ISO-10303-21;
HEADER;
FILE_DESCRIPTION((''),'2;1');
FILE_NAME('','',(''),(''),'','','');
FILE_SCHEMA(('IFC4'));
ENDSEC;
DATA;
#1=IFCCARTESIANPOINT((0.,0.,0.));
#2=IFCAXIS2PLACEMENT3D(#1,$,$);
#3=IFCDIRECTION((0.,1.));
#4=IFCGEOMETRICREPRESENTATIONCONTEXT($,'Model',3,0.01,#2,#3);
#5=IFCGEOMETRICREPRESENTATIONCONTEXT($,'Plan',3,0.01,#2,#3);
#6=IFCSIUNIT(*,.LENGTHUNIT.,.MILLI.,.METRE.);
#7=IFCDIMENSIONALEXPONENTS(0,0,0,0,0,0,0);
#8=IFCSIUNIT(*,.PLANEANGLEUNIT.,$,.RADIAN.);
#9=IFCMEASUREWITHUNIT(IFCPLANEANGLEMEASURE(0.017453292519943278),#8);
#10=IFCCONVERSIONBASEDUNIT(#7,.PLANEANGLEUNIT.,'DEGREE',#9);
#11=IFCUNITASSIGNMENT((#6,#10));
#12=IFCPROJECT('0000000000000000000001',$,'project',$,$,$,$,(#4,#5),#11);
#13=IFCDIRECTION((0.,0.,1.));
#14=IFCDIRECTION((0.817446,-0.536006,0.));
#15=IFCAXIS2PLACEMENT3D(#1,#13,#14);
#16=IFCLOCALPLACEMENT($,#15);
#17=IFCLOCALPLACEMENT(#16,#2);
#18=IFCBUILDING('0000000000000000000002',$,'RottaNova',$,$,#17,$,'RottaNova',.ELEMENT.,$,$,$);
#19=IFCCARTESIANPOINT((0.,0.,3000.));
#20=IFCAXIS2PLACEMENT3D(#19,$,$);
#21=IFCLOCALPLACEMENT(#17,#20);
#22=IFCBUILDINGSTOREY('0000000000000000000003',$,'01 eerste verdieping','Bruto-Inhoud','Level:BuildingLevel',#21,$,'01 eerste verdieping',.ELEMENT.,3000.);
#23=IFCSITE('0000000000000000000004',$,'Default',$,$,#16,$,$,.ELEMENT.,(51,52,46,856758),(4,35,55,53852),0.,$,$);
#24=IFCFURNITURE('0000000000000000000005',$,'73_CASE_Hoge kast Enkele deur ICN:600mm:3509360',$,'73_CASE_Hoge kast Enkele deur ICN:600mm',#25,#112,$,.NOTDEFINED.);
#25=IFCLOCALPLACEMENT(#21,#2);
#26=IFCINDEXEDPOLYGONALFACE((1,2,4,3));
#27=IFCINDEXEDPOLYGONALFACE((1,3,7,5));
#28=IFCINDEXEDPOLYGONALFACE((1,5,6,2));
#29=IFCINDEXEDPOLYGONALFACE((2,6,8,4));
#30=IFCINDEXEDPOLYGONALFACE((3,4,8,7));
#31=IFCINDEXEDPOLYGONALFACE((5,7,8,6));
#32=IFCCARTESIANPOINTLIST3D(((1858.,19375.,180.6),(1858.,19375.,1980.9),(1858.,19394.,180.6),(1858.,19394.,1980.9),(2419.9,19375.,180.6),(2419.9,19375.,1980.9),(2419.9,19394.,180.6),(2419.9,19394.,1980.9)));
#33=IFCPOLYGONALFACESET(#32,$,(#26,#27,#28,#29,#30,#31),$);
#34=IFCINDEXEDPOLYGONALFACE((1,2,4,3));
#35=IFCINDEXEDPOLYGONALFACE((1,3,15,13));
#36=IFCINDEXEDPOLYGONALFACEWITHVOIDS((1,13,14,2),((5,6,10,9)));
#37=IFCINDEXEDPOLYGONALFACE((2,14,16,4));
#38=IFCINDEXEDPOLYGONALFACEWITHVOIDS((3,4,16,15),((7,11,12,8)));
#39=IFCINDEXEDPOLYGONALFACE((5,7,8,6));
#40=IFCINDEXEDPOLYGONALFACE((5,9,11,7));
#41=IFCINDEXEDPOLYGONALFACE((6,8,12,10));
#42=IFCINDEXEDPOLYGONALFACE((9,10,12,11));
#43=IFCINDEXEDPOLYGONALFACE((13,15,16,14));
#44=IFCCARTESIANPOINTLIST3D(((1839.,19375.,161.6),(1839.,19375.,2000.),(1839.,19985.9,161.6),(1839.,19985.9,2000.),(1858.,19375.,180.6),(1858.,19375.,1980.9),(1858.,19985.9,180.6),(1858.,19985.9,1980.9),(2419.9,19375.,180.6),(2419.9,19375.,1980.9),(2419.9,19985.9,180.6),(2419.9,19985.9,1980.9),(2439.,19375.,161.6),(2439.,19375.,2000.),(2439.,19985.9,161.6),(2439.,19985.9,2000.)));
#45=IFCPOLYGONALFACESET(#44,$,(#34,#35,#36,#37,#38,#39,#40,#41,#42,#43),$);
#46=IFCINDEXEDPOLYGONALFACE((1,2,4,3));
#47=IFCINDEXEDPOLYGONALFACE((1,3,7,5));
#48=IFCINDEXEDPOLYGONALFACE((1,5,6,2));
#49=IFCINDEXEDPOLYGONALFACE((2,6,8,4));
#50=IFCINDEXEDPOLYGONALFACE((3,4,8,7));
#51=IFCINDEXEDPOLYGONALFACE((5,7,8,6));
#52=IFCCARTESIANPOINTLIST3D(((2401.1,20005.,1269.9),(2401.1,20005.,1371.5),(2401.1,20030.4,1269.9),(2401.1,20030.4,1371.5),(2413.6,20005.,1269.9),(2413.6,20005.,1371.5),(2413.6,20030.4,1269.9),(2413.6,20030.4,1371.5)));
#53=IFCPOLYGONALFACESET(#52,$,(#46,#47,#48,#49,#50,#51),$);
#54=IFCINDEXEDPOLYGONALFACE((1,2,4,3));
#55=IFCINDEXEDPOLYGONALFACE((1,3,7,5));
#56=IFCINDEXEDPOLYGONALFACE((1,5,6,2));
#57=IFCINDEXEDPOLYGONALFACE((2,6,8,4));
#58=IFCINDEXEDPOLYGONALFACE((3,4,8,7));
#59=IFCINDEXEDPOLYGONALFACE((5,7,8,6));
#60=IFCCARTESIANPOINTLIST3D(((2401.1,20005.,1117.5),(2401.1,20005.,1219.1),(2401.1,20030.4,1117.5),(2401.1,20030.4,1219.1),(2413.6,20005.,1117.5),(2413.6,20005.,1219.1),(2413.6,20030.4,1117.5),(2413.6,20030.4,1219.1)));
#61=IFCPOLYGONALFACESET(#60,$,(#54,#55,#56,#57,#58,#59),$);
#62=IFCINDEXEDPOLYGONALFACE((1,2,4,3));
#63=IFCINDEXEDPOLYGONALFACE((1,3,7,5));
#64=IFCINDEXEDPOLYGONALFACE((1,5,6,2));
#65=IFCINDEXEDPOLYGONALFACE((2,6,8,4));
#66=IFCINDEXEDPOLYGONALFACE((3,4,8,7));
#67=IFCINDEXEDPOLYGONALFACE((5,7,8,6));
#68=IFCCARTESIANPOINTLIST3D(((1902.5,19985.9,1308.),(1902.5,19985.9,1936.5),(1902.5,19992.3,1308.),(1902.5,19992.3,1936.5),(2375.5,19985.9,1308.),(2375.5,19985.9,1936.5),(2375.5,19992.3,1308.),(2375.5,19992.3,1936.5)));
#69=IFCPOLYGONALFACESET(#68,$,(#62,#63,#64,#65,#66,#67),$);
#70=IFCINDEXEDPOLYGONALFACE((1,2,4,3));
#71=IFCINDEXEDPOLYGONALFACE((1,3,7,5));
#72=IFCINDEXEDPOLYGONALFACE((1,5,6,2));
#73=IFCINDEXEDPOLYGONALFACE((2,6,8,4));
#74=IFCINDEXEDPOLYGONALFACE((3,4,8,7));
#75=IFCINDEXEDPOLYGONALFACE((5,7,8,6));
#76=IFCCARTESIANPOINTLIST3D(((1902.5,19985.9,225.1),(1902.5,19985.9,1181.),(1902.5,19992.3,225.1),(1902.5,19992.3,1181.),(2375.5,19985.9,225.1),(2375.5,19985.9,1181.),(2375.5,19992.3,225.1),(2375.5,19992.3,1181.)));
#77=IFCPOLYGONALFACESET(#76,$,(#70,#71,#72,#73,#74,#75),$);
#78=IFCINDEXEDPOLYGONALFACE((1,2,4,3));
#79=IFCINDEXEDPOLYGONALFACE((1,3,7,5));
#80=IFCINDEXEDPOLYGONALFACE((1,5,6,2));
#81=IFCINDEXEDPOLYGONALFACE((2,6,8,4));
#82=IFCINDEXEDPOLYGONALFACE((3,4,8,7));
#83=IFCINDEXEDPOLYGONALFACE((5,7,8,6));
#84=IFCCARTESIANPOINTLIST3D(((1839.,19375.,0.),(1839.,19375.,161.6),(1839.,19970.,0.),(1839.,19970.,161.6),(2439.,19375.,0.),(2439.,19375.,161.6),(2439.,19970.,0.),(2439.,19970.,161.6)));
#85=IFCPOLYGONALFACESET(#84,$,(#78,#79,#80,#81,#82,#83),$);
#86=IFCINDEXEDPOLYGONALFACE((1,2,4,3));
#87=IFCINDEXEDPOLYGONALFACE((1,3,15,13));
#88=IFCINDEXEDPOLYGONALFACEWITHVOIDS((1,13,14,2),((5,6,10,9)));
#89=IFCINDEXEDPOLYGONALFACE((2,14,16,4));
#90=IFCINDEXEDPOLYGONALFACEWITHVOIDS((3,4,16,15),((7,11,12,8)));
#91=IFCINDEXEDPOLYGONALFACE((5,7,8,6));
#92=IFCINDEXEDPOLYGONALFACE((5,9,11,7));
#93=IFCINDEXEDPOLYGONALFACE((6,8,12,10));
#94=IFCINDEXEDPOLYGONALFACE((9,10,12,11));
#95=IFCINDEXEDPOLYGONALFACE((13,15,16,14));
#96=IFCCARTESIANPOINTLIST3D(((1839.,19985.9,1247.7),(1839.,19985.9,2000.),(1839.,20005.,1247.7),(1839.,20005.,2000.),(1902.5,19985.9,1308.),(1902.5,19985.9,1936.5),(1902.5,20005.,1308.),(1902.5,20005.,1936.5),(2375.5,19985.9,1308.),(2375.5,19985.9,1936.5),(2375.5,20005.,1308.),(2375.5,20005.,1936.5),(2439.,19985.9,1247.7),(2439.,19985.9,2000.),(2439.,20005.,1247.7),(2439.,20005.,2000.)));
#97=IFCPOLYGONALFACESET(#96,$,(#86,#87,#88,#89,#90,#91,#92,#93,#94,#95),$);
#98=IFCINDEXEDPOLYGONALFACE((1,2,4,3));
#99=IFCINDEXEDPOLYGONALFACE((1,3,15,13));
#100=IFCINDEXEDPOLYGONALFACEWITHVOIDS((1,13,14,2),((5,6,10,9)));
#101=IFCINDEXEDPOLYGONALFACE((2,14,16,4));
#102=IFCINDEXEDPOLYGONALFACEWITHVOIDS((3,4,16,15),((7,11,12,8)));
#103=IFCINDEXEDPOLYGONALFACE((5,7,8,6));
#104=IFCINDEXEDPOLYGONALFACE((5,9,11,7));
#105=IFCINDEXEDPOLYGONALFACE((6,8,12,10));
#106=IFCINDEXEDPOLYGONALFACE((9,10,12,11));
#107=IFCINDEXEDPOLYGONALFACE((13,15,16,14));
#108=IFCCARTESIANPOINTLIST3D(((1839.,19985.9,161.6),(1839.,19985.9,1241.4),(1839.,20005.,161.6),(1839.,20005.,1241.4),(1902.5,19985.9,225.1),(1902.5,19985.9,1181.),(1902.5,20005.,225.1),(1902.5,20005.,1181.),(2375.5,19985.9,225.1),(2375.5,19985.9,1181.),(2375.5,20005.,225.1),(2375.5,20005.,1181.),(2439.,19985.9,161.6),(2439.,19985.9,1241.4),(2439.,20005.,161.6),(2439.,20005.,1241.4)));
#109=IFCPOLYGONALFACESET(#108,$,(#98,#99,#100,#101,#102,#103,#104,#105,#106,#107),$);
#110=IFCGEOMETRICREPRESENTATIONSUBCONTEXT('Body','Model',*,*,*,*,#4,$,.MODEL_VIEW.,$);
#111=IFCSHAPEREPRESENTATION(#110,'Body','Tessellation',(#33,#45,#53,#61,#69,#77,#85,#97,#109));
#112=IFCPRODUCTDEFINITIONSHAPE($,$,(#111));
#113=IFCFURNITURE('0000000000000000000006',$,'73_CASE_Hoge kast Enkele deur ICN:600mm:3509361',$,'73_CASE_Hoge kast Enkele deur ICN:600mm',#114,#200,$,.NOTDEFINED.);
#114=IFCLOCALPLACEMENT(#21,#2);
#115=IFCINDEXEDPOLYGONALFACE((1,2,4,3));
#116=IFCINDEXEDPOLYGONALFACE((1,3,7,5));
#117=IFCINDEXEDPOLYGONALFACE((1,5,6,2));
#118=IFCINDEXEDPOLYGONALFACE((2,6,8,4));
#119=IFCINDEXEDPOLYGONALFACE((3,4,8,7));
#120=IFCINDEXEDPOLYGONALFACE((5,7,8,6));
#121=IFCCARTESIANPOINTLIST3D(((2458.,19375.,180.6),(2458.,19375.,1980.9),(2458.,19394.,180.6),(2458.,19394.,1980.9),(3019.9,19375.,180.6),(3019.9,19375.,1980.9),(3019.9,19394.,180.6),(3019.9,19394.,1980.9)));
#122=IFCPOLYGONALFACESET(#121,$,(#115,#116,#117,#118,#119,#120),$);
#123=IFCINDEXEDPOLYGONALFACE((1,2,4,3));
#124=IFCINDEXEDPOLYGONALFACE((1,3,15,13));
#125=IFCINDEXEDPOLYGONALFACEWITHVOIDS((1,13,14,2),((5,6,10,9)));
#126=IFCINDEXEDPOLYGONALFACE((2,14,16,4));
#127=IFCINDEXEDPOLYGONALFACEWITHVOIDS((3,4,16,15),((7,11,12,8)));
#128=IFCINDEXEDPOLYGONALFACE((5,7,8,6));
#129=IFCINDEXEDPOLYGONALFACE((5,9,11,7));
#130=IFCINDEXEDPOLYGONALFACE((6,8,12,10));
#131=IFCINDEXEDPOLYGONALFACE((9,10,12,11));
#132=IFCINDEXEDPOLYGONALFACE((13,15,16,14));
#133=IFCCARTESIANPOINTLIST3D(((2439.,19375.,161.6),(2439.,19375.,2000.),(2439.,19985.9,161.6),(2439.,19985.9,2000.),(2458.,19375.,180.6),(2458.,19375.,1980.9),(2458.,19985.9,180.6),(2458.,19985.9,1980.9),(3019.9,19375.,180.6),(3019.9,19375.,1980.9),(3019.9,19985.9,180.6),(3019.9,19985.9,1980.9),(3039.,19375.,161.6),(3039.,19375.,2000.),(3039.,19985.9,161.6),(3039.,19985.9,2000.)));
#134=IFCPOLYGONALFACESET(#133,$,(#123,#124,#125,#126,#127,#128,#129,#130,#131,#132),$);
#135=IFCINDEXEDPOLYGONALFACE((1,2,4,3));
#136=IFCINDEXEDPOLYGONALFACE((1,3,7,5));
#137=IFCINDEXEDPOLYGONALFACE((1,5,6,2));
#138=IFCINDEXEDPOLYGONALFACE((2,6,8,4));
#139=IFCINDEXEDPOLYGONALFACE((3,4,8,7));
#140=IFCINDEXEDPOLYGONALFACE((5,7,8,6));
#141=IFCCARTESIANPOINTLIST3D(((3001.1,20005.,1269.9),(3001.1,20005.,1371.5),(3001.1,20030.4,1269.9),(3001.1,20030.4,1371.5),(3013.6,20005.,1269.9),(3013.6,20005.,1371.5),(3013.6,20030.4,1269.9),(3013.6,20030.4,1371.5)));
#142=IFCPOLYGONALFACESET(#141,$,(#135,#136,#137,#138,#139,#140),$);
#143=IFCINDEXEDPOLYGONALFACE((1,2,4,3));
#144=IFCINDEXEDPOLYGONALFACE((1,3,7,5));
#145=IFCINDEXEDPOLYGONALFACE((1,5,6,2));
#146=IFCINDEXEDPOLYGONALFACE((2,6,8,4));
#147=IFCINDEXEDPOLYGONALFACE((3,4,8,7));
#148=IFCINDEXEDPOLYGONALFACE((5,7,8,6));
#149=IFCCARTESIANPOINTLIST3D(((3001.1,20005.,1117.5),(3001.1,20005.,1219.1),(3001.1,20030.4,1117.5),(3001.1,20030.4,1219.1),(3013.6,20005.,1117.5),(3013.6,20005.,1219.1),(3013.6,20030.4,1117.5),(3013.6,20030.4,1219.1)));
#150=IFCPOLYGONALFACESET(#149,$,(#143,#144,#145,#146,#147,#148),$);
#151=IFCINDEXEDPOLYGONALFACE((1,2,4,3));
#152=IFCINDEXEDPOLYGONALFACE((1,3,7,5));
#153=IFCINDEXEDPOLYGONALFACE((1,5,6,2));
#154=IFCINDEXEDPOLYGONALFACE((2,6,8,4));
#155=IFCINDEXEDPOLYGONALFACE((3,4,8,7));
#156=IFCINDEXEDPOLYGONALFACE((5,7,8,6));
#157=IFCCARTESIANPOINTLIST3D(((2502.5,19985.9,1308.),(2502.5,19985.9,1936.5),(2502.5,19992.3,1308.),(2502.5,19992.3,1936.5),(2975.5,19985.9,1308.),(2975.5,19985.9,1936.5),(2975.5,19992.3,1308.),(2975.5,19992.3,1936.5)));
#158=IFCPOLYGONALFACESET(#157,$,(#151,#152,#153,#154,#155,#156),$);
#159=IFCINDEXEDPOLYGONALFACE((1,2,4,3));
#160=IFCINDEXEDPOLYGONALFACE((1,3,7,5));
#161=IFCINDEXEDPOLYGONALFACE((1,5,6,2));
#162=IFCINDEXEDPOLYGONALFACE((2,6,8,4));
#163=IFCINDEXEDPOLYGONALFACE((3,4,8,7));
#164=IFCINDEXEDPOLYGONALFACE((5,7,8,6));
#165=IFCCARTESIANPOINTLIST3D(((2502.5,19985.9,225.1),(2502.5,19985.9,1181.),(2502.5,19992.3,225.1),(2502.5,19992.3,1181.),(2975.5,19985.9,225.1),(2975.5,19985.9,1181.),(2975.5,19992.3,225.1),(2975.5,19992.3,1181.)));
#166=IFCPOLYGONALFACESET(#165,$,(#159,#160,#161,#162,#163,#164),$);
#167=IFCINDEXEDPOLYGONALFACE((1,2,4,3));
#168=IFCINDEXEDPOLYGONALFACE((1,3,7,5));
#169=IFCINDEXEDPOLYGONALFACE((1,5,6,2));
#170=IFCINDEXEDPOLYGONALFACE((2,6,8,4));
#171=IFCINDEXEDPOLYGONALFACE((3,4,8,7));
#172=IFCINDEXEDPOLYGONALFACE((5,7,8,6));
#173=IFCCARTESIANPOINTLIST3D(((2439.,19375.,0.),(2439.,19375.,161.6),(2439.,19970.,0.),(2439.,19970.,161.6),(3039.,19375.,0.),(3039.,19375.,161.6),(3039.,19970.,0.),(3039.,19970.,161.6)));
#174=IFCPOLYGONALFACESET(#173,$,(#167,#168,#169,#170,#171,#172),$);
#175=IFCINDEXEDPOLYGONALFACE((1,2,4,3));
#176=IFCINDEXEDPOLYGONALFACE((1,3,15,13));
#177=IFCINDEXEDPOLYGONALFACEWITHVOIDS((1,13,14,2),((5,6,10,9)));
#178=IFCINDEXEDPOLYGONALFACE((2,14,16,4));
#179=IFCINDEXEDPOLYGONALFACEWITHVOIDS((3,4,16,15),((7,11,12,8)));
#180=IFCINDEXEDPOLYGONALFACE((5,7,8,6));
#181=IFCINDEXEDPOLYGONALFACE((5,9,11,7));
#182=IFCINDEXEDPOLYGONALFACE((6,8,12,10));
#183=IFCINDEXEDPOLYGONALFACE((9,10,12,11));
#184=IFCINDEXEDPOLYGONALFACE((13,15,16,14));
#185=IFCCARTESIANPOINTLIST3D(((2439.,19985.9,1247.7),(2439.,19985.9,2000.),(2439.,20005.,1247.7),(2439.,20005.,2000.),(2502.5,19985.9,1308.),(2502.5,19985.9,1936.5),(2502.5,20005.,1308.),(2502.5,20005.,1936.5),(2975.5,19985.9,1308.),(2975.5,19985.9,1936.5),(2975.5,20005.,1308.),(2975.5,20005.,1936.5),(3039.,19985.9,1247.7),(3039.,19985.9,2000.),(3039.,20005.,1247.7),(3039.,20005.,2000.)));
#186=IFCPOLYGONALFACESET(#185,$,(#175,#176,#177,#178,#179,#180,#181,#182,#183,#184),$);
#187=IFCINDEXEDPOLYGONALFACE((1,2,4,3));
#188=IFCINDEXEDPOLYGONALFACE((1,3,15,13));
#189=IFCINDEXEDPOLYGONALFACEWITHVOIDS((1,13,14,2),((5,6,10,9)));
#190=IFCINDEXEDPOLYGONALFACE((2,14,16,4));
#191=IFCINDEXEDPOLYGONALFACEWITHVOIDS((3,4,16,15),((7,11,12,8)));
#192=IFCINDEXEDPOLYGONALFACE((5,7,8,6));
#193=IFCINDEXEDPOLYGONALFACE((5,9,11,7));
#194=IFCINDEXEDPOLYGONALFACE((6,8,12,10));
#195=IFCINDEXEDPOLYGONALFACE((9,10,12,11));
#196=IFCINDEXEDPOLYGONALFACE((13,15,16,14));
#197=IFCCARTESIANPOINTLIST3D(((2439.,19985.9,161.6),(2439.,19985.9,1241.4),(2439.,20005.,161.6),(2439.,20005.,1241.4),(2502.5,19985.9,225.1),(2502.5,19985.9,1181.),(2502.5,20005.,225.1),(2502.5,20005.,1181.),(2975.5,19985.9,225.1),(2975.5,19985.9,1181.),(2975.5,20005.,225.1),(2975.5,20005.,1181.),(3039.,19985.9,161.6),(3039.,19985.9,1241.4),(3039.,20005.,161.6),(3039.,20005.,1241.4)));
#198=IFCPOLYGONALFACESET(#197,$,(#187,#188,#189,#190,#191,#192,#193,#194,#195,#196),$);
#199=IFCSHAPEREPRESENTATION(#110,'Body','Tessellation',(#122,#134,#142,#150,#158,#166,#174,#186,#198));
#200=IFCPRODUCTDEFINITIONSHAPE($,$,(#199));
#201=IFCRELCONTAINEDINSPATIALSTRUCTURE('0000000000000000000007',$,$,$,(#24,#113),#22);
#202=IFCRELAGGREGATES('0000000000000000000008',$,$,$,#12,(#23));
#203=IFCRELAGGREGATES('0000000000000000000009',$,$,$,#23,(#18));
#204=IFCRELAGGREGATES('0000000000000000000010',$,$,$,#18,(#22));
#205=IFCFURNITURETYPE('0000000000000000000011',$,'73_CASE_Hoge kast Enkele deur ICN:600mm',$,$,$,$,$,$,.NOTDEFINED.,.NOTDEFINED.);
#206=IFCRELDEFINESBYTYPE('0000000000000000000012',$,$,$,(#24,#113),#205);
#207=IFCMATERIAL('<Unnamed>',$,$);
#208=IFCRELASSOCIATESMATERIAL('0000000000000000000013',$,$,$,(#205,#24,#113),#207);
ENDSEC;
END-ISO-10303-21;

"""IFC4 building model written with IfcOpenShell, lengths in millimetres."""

from ifc_helpers import new_model, entity, si_unit, converted_unit, direction, frame, origin, place, context, subcontext, project, spatial, indexed_curve, outline, extrude, source, transform, mapped, material, type_object, type_shapes, element, save


model = new_model("IFC4")

# Units and contexts
model_context = context("Model", 3, precision=0.01, world=origin(), true_north=direction((0.0, 1.0)))
plan_context = context("Plan", 3, precision=0.01, world=origin(), true_north=direction((0.0, 1.0)))
body_context = subcontext(model_context, "Body", "Model", "MODEL_VIEW")
ifc_project = project(units=[si_unit("LENGTHUNIT", "METRE", prefix="MILLI"), converted_unit("PLANEANGLEUNIT", "DEGREE", entity("IfcPlaneAngleMeasure", 0.017453292519943278), si_unit("PLANEANGLEUNIT", "RADIAN"), dimensions=[0, 0, 0, 0, 0, 0, 0])], contexts=[model_context, plan_context])

# Site, building, storey
site_placement = place(None, frame((0.0, 0.0, 0.0), z_axis=(0.0, 0.0, 1.0), x_axis=(0.817446, -0.536006, 0.0)))
site = spatial("IfcSite", under=ifc_project, at=site_placement, Name="Default", CompositionType="ELEMENT", RefLatitude=(51, 52, 46, 856758), RefLongitude=(4, 35, 55, 53852), RefElevation=0.0)
building_placement = place(site_placement, origin())
building = spatial("IfcBuilding", under=site, at=building_placement, Name="RottaNova", LongName="RottaNova", CompositionType="ELEMENT")
storey_placement = place(building_placement, frame((0.0, 0.0, 3000.0)))
storey = spatial("IfcBuildingStorey", under=building, at=storey_placement, Name="01 eerste verdieping", Description="Bruto-Inhoud", ObjectType="Level:BuildingLevel", LongName="01 eerste verdieping", CompositionType="ELEMENT", Elevation=3000.0)

# Furniture
ifc_material_1 = material(Name="<Unnamed>")
furniture_type = type_object("IfcFurnitureType", Name="73_CASE_Hoge kast Enkele deur ICN:600mm", AssemblyPlace="NOTDEFINED", PredefinedType="NOTDEFINED", material=ifc_material_1)
shared_shape_1 = source(origin(), body_context, "Body", "SweptSolid", [
    extrude(outline(indexed_curve([(-280.9, -9.5), (280.9, -9.5), (280.9, 9.5), (-280.9, 9.5), (-280.9, -9.5)], self_intersect=False)), frame((18.7, 9.5, 180.6), z_axis=(0.0, 0.0, 1.0), x_axis=(-1.0, 0.0, 0.0)), (0.0, 0.0, 1.0), 1800.3),
    extrude(outline(indexed_curve([(-300.0, -919.2), (300.0, -919.2), (300.0, 919.2), (-300.0, 919.2), (-300.0, -919.2)], self_intersect=False), holes=[indexed_curve([(-280.9, 900.2), (281.0, 900.2), (281.0, -900.2), (-280.9, -900.2), (-280.9, 900.2)], self_intersect=False)]), frame((18.7, 0.0, 1080.8), z_axis=(0.0, 1.0, 0.0), x_axis=(-1.0, 0.0, 0.0)), (0.0, 0.0, 1.0), 610.9),
    extrude(outline(indexed_curve([(-6.3, -12.7), (6.3, -12.7), (6.3, 12.7), (-6.3, 12.7), (-6.3, -12.7)], self_intersect=False)), frame((287.1, 642.7, 1269.9), z_axis=(0.0, 0.0, 1.0), x_axis=(-1.0, 0.0, 0.0)), (0.0, 0.0, 1.0), 101.6),
    extrude(outline(indexed_curve([(-6.3, -12.7), (6.3, -12.7), (6.3, 12.7), (-6.3, 12.7), (-6.3, -12.7)], self_intersect=False)), frame((287.1, 642.7, 1117.5), z_axis=(0.0, 0.0, 1.0), x_axis=(-1.0, 0.0, 0.0)), (0.0, 0.0, 1.0), 101.6),
    extrude(outline(indexed_curve([(-236.5, -3.2), (236.5, -3.2), (236.5, 3.2), (-236.5, 3.2), (-236.5, -3.2)], self_intersect=False)), frame((18.7, 614.1, 1308.0), z_axis=(0.0, 0.0, 1.0), x_axis=(-1.0, 0.0, 0.0)), (0.0, 0.0, 1.0), 628.5),
    extrude(outline(indexed_curve([(-236.5, -3.2), (236.5, -3.2), (236.5, 3.2), (-236.5, 3.2), (-236.5, -3.2)], self_intersect=False)), frame((18.7, 614.1, 225.1), z_axis=(0.0, 0.0, 1.0), x_axis=(-1.0, 0.0, 0.0)), (0.0, 0.0, 1.0), 956.0),
    extrude(outline(indexed_curve([(-297.5, -300.0), (297.5, -300.0), (297.5, 300.0), (-297.5, 300.0), (-297.5, -300.0)], self_intersect=False)), frame((18.7, 297.5, 0.0), z_axis=(0.0, 0.0, 1.0), x_axis=(0.0, 1.0, 0.0)), (0.0, 0.0, 1.0), 161.6),
    extrude(outline(indexed_curve([(-376.1, -300.0), (376.1, -300.0), (376.1, 300.0), (-376.1, 300.0), (-376.1, -300.0)], self_intersect=False), holes=[indexed_curve([(-312.6, -236.5), (-312.6, 236.5), (315.8, 236.5), (315.8, -236.5), (-312.6, -236.5)], self_intersect=False)]), frame((18.7, 610.9, 1623.9), z_axis=(0.0, 1.0, 0.0), x_axis=(0.0, 0.0, -1.0)), (0.0, 0.0, 1.0), 19.1),
    extrude(outline(indexed_curve([(-300.0, -539.9), (300.0, -539.9), (300.0, 539.9), (-300.0, 539.9), (-300.0, -539.9)], self_intersect=False), holes=[indexed_curve([(-236.5, 479.6), (236.5, 479.6), (236.5, -476.4), (-236.5, -476.4), (-236.5, 479.6)], self_intersect=False)]), frame((18.7, 610.9, 701.5), z_axis=(0.0, 1.0, 0.0), x_axis=(-1.0, 0.0, 0.0)), (0.0, 0.0, 1.0), 19.1),
])
type_shapes(furniture_type, [shared_shape_1])
for number, where, name in (
    (1, (2120.3, 19375.0, 0.0), "73_CASE_Hoge kast Enkele deur ICN:600mm:3509360"),
    (2, (2720.3, 19375.0, 0.0), "73_CASE_Hoge kast Enkele deur ICN:600mm:3509361"),
):
    element("IfcFurniture", number, at=place(storey_placement, frame(where)), inside=storey, type_object=furniture_type, material=ifc_material_1, Name=name, ObjectType="73_CASE_Hoge kast Enkele deur ICN:600mm", PredefinedType="NOTDEFINED", context=body_context, shape_type="MappedRepresentation", body=[
        mapped(shared_shape_1, transform((0.0, 0.0, 0.0), scale=1.0)),
    ])

save(model, "model.ifc")
